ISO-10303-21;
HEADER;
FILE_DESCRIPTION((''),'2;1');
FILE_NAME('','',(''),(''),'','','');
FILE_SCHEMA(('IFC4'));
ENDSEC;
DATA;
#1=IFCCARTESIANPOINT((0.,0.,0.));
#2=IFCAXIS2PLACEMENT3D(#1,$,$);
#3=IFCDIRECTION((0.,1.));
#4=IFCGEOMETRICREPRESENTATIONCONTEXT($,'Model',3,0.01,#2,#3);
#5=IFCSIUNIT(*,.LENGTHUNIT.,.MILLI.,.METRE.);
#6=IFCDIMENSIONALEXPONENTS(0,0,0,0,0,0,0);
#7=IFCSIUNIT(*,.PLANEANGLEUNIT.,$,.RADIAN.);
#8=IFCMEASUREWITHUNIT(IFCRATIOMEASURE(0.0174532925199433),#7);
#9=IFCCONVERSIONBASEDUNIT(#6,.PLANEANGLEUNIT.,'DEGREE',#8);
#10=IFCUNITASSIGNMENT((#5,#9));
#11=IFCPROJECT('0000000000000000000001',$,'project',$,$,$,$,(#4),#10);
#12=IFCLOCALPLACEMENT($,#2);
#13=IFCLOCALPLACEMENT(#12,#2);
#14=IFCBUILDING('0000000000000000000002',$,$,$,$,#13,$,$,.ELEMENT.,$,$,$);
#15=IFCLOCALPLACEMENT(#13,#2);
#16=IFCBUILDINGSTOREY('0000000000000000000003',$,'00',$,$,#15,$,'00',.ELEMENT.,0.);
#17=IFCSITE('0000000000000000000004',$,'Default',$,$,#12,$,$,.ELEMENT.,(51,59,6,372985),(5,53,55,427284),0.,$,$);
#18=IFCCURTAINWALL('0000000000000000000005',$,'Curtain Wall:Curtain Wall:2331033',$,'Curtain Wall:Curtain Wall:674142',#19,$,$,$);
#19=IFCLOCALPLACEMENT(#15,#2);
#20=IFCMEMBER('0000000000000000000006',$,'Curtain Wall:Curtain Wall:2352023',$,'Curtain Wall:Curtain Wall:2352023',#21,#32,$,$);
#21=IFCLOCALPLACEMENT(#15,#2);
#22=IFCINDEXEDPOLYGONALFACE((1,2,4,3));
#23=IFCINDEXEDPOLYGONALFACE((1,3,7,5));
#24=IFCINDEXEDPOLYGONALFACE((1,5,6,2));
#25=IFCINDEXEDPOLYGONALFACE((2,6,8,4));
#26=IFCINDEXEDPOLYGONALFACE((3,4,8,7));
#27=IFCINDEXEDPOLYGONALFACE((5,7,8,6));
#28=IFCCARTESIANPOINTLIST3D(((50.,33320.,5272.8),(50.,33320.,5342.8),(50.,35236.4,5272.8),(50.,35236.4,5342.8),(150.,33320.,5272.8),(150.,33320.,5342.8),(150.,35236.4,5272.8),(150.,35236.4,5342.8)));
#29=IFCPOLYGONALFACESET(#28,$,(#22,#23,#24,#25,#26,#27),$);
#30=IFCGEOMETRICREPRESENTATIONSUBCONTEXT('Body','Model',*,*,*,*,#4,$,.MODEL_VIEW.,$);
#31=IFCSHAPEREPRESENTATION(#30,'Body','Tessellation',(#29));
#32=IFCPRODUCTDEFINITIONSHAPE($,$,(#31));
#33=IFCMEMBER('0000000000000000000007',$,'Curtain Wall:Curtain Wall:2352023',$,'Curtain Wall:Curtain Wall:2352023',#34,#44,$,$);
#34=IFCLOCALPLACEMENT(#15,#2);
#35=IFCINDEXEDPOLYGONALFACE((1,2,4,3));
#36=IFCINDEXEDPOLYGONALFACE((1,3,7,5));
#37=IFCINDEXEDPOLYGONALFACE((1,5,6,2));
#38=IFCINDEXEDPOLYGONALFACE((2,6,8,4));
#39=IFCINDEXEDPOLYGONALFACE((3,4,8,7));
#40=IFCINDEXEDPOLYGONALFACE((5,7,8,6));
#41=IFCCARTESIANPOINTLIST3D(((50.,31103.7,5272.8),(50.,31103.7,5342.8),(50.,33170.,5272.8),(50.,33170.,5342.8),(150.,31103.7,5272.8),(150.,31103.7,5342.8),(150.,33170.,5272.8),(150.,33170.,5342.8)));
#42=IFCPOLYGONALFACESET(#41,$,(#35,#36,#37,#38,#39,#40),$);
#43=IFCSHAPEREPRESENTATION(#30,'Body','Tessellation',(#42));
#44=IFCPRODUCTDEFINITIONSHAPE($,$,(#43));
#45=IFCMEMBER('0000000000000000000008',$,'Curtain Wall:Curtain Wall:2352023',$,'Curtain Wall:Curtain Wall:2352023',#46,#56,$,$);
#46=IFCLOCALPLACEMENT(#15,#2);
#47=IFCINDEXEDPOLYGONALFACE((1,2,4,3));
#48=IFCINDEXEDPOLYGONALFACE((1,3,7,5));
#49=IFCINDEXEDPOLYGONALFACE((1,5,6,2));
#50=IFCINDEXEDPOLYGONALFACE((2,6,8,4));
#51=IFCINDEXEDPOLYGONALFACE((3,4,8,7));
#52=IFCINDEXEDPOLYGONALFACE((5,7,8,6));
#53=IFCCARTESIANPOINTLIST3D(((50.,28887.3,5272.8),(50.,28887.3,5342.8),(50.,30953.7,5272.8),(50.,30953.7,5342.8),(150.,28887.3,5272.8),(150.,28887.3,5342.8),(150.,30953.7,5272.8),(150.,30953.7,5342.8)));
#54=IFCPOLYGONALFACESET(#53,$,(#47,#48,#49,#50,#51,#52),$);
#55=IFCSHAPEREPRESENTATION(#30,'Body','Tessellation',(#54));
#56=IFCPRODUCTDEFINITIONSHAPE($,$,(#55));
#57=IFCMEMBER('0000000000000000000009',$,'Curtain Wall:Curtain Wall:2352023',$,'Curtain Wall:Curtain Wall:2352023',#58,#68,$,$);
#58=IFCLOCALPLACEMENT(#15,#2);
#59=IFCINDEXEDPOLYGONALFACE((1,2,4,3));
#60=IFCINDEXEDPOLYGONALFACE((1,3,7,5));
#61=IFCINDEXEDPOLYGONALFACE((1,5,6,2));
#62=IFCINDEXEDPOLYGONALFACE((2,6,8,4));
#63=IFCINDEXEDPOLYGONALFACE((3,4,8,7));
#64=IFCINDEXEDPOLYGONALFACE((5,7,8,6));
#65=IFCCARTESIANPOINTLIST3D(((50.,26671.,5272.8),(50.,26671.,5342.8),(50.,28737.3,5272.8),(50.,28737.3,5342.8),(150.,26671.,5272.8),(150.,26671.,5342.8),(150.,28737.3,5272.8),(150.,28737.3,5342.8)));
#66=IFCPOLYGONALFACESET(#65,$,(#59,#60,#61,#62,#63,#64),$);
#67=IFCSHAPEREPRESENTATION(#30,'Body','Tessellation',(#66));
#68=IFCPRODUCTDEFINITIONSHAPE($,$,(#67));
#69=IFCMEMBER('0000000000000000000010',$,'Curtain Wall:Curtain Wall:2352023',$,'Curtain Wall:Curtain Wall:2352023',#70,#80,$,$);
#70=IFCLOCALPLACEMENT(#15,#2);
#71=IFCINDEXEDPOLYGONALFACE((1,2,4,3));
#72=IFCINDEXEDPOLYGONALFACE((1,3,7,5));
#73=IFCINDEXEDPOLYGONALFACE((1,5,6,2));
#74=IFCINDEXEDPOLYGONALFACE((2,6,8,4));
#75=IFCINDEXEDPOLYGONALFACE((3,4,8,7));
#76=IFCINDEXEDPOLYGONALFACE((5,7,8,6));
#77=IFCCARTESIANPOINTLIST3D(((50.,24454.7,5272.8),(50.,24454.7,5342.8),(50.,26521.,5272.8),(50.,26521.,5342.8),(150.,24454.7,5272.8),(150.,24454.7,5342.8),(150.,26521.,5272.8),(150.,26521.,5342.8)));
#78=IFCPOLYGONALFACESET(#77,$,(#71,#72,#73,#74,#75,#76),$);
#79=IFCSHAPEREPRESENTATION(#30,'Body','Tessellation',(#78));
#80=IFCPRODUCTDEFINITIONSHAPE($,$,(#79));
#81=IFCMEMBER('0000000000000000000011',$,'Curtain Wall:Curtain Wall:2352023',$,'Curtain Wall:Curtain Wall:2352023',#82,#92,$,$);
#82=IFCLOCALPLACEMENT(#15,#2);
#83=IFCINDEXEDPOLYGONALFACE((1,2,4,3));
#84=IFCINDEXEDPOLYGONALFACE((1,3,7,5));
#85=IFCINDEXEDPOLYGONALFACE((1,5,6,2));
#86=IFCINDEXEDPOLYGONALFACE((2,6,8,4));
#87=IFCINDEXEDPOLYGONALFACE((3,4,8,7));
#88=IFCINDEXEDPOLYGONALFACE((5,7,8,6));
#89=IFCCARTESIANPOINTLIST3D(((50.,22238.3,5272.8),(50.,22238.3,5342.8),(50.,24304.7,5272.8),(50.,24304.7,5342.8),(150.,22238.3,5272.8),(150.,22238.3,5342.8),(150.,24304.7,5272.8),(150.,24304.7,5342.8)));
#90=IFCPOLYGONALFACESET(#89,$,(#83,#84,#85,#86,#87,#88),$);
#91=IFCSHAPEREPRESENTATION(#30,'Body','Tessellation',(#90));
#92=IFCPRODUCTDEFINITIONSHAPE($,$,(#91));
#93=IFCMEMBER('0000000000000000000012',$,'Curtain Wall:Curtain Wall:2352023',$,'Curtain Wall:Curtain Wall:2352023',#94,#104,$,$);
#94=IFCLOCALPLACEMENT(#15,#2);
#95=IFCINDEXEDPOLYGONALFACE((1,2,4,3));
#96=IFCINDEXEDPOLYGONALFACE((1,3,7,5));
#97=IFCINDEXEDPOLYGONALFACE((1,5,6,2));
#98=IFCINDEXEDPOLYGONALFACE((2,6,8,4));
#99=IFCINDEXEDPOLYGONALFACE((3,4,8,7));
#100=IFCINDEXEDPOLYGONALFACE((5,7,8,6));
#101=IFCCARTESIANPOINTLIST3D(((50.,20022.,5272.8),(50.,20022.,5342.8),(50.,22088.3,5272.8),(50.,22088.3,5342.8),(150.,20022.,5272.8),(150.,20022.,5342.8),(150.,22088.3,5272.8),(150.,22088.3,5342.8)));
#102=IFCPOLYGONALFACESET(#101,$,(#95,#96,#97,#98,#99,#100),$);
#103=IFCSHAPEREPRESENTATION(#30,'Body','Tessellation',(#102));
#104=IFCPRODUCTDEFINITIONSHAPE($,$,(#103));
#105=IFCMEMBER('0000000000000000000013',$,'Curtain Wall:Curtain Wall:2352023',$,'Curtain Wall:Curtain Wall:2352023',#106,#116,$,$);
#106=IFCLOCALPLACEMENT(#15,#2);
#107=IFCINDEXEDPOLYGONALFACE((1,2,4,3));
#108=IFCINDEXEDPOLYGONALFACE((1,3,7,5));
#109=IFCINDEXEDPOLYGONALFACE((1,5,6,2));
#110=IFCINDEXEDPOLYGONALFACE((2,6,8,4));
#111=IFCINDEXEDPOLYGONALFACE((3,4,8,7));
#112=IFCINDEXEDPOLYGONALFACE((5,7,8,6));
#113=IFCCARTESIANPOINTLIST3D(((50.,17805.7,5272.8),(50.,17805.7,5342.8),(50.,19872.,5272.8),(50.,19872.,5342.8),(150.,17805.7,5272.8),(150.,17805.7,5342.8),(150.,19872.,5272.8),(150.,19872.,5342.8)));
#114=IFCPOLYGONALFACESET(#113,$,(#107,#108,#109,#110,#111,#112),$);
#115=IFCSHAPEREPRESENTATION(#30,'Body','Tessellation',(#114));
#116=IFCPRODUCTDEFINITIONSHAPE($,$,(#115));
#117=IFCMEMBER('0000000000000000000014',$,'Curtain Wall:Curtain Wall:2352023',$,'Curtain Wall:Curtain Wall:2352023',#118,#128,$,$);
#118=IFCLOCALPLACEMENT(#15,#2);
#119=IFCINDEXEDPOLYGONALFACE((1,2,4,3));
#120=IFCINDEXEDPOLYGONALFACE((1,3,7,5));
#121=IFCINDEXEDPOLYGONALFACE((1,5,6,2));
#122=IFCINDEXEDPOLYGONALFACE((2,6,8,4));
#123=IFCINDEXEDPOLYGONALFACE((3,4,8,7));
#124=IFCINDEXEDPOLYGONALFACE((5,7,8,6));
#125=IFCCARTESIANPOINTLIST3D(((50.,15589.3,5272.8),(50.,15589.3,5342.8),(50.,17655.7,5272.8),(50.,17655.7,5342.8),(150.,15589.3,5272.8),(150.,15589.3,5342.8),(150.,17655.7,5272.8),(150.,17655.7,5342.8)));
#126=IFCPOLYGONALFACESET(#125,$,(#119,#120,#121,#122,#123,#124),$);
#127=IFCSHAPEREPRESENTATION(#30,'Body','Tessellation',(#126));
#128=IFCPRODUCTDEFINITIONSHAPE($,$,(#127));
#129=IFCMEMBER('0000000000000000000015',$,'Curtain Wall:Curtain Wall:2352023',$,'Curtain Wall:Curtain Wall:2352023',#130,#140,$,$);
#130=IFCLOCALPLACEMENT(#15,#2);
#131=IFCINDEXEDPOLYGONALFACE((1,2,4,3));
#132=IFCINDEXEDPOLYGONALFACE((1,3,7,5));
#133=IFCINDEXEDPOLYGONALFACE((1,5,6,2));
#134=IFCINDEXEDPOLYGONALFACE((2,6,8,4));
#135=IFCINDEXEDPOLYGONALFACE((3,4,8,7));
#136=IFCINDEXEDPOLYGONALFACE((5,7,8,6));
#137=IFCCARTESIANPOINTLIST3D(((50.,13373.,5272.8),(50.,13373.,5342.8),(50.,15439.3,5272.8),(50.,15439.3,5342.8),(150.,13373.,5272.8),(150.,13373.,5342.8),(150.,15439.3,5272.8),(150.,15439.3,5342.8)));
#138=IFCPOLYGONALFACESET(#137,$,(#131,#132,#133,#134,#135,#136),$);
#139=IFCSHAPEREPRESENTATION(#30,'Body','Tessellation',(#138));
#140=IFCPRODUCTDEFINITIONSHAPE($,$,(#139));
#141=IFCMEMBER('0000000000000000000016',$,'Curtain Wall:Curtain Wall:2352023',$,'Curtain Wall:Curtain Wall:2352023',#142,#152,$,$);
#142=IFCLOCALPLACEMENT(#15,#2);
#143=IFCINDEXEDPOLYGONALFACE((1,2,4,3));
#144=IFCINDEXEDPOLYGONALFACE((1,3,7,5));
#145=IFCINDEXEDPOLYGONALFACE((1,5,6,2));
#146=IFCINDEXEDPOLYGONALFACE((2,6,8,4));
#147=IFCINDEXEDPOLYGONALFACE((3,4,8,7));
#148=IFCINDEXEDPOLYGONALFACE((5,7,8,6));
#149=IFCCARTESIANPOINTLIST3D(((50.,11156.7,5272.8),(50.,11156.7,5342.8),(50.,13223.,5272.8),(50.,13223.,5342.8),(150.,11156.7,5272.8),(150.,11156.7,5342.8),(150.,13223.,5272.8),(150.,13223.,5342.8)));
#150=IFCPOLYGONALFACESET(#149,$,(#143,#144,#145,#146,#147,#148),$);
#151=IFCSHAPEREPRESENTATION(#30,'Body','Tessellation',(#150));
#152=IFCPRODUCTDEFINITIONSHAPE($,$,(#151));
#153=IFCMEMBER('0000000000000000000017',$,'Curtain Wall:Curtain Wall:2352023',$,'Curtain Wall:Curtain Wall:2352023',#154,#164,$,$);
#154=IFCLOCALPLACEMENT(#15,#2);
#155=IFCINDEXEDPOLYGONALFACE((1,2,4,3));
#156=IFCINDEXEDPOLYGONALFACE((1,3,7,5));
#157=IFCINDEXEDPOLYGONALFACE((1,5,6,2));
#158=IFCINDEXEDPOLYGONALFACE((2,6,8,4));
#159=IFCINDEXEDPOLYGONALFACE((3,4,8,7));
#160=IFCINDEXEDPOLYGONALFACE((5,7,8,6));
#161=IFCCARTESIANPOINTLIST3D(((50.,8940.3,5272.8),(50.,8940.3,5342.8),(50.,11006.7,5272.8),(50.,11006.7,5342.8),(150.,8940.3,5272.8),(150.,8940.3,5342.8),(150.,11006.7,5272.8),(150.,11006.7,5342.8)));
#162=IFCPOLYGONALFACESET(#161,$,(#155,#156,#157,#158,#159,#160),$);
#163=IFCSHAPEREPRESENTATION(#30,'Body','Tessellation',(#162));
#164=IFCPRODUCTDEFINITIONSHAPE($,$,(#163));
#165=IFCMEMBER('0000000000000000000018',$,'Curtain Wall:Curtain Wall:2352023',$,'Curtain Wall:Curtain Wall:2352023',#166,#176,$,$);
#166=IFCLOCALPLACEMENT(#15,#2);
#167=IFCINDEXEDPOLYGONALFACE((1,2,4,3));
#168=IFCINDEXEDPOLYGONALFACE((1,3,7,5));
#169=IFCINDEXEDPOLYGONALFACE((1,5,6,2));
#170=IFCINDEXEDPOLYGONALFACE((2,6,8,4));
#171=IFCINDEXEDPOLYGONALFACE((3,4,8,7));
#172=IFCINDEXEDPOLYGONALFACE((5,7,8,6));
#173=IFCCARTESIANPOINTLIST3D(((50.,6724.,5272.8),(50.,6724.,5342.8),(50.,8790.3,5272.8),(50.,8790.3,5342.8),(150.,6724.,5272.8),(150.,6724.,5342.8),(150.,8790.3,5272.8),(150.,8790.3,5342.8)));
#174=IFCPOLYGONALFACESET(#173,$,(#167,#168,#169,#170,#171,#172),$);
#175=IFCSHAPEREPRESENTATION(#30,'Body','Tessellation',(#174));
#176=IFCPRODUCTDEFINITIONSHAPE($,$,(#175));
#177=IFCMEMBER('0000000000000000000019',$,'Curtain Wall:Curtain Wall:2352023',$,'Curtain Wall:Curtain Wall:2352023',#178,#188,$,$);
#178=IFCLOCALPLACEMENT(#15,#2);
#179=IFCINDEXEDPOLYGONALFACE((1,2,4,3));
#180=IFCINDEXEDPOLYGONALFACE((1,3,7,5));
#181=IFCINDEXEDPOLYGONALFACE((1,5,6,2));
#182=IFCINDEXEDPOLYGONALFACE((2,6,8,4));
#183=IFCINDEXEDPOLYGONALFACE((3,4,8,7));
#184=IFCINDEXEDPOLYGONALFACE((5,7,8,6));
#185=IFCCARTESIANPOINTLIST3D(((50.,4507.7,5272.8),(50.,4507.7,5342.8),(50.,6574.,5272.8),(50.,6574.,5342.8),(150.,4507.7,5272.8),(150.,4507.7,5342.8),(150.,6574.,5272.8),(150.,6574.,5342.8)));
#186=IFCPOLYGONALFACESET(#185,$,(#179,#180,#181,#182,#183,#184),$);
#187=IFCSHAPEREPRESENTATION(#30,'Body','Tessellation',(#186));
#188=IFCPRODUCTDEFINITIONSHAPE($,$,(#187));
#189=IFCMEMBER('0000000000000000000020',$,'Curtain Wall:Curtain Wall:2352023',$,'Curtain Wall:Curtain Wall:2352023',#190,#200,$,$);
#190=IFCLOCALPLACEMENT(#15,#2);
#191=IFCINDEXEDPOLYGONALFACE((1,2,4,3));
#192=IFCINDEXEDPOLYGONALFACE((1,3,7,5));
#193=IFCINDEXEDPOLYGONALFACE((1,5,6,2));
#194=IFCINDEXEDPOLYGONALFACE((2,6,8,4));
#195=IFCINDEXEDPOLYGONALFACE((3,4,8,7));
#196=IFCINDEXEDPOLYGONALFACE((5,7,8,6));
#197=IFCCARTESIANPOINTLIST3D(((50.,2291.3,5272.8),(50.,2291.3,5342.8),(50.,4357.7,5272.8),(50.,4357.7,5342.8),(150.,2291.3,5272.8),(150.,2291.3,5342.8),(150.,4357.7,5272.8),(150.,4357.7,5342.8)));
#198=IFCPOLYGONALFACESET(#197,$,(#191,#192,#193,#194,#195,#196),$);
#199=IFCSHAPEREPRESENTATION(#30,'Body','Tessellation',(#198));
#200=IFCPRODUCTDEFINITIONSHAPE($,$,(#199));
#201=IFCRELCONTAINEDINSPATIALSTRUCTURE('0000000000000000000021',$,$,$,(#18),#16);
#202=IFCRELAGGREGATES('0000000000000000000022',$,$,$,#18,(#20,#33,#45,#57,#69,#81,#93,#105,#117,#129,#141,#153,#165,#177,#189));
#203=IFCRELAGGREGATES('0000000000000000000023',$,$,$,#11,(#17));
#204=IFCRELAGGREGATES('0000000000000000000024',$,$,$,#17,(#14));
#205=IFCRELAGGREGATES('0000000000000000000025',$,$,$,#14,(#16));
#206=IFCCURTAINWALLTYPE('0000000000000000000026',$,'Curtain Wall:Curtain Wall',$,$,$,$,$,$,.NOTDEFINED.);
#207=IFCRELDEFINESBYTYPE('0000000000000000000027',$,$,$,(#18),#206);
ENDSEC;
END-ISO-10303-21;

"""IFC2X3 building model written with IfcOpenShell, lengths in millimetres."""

from ifc_helpers import new_model, entity, si_unit, converted_unit, direction, frame, frame_2d, origin, origin_2d_with_axis, place, context, subcontext, project, spatial, rectangle, extrude, type_object, element, aggregate, save


model = new_model("IFC2X3")

# Units and contexts
model_context = context("Model", 3, precision=0.01, world=origin(), true_north=direction((0.0, 1.0)))
body_context = subcontext(model_context, "Body", "Model", "MODEL_VIEW")
ifc_project = project(units=[si_unit("LENGTHUNIT", "METRE", prefix="MILLI"), converted_unit("PLANEANGLEUNIT", "DEGREE", entity("IfcRatioMeasure", 0.0174532925199433), si_unit("PLANEANGLEUNIT", "RADIAN"), dimensions=[0, 0, 0, 0, 0, 0, 0])], contexts=[model_context])

# Site, building, storey
site_placement = place(None, origin())
site = spatial("IfcSite", under=ifc_project, at=site_placement, Name="Default", CompositionType="ELEMENT", RefLatitude=(51, 59, 6, 372985), RefLongitude=(5, 53, 55, 427284), RefElevation=0.0)
building_placement = place(site_placement, origin())
building = spatial("IfcBuilding", under=site, at=building_placement, CompositionType="ELEMENT")
storey_placement = place(building_placement, origin())
storey = spatial("IfcBuildingStorey", under=building, at=storey_placement, Name="00", LongName="00", CompositionType="ELEMENT", Elevation=0.0)

# Curtain wall, members
curtain_wall_type = type_object("IfcCurtainWallType", Name="Curtain Wall:Curtain Wall", PredefinedType="NOTDEFINED")
curtain_wall_placement = place(storey_placement, origin())
curtain_wall = element("IfcCurtainWall", 1, at=curtain_wall_placement, inside=storey, type_object=curtain_wall_type, Name="Curtain Wall:Curtain Wall:2331033", ObjectType="Curtain Wall:Curtain Wall:674142")
member_1_placement = place(curtain_wall_placement, origin())
member_1 = element("IfcMember", 2, at=member_1_placement, Name="Curtain Wall:Curtain Wall:2352023", ObjectType="Curtain Wall:Curtain Wall:2352023", context=body_context, shape_type="SweptSolid", body=[
    extrude(rectangle(XDim=70.0, YDim=100.0, at=frame_2d((0.0, 0.0), x_axis=(1.0, 0.0))), frame((100.0, 33320.0, 5307.8), z_axis=(0.0, 1.0, 0.0), x_axis=(0.0, 0.0, -1.0)), (0.0, 0.0, 1.0), 1916.3),
])
member_2_placement = place(curtain_wall_placement, origin())
member_2 = element("IfcMember", 3, at=member_2_placement, Name="Curtain Wall:Curtain Wall:2352023", ObjectType="Curtain Wall:Curtain Wall:2352023", context=body_context, shape_type="SweptSolid", body=[
    extrude(rectangle(XDim=70.0, YDim=100.0, at=origin_2d_with_axis()), frame((100.0, 31103.7, 5307.8), z_axis=(0.0, 1.0, 0.0), x_axis=(0.0, 0.0, -1.0)), (0.0, 0.0, 1.0), 2066.3),
])
member_3_placement = place(curtain_wall_placement, origin())
member_3 = element("IfcMember", 4, at=member_3_placement, Name="Curtain Wall:Curtain Wall:2352023", ObjectType="Curtain Wall:Curtain Wall:2352023", context=body_context, shape_type="SweptSolid", body=[
    extrude(rectangle(XDim=70.0, YDim=100.0, at=frame_2d((0.0, 0.0), x_axis=(1.0, 0.0))), frame((100.0, 28887.3, 5307.8), z_axis=(0.0, 1.0, 0.0), x_axis=(0.0, 0.0, -1.0)), (0.0, 0.0, 1.0), 2066.3),
])
member_4_placement = place(curtain_wall_placement, origin())
member_4 = element("IfcMember", 5, at=member_4_placement, Name="Curtain Wall:Curtain Wall:2352023", ObjectType="Curtain Wall:Curtain Wall:2352023", context=body_context, shape_type="SweptSolid", body=[
    extrude(rectangle(XDim=70.0, YDim=100.0, at=origin_2d_with_axis()), frame((100.0, 26671.0, 5307.8), z_axis=(0.0, 1.0, 0.0), x_axis=(0.0, 0.0, -1.0)), (0.0, 0.0, 1.0), 2066.3),
])
member_5_placement = place(curtain_wall_placement, origin())
member_5 = element("IfcMember", 6, at=member_5_placement, Name="Curtain Wall:Curtain Wall:2352023", ObjectType="Curtain Wall:Curtain Wall:2352023", context=body_context, shape_type="SweptSolid", body=[
    extrude(rectangle(XDim=70.0, YDim=100.0, at=origin_2d_with_axis()), frame((100.0, 24454.7, 5307.8), z_axis=(0.0, 1.0, 0.0), x_axis=(0.0, 0.0, -1.0)), (0.0, 0.0, 1.0), 2066.3),
])
member_6_placement = place(curtain_wall_placement, origin())
member_6 = element("IfcMember", 7, at=member_6_placement, Name="Curtain Wall:Curtain Wall:2352023", ObjectType="Curtain Wall:Curtain Wall:2352023", context=body_context, shape_type="SweptSolid", body=[
    extrude(rectangle(XDim=70.0, YDim=100.0, at=frame_2d((0.0, 0.0), x_axis=(1.0, 0.0))), frame((100.0, 22238.3, 5307.8), z_axis=(0.0, 1.0, 0.0), x_axis=(0.0, 0.0, -1.0)), (0.0, 0.0, 1.0), 2066.3),
])
member_7_placement = place(curtain_wall_placement, origin())
member_7 = element("IfcMember", 8, at=member_7_placement, Name="Curtain Wall:Curtain Wall:2352023", ObjectType="Curtain Wall:Curtain Wall:2352023", context=body_context, shape_type="SweptSolid", body=[
    extrude(rectangle(XDim=70.0, YDim=100.0, at=origin_2d_with_axis()), frame((100.0, 20022.0, 5307.8), z_axis=(0.0, 1.0, 0.0), x_axis=(0.0, 0.0, -1.0)), (0.0, 0.0, 1.0), 2066.3),
])
member_8_placement = place(curtain_wall_placement, origin())
member_8 = element("IfcMember", 9, at=member_8_placement, Name="Curtain Wall:Curtain Wall:2352023", ObjectType="Curtain Wall:Curtain Wall:2352023", context=body_context, shape_type="SweptSolid", body=[
    extrude(rectangle(XDim=70.0, YDim=100.0, at=frame_2d((0.0, 0.0), x_axis=(1.0, 0.0))), frame((100.0, 17805.7, 5307.8), z_axis=(0.0, 1.0, 0.0), x_axis=(0.0, 0.0, -1.0)), (0.0, 0.0, 1.0), 2066.3),
])
member_9_placement = place(curtain_wall_placement, origin())
member_9 = element("IfcMember", 10, at=member_9_placement, Name="Curtain Wall:Curtain Wall:2352023", ObjectType="Curtain Wall:Curtain Wall:2352023", context=body_context, shape_type="SweptSolid", body=[
    extrude(rectangle(XDim=70.0, YDim=100.0, at=origin_2d_with_axis()), frame((100.0, 15589.3, 5307.8), z_axis=(0.0, 1.0, 0.0), x_axis=(0.0, 0.0, -1.0)), (0.0, 0.0, 1.0), 2066.3),
])
member_10_placement = place(curtain_wall_placement, origin())
member_10 = element("IfcMember", 11, at=member_10_placement, Name="Curtain Wall:Curtain Wall:2352023", ObjectType="Curtain Wall:Curtain Wall:2352023", context=body_context, shape_type="SweptSolid", body=[
    extrude(rectangle(XDim=70.0, YDim=100.0, at=origin_2d_with_axis()), frame((100.0, 13373.0, 5307.8), z_axis=(0.0, 1.0, 0.0), x_axis=(0.0, 0.0, -1.0)), (0.0, 0.0, 1.0), 2066.3),
])
member_11_placement = place(curtain_wall_placement, origin())
member_11 = element("IfcMember", 12, at=member_11_placement, Name="Curtain Wall:Curtain Wall:2352023", ObjectType="Curtain Wall:Curtain Wall:2352023", context=body_context, shape_type="SweptSolid", body=[
    extrude(rectangle(XDim=70.0, YDim=100.0, at=origin_2d_with_axis()), frame((100.0, 11156.7, 5307.8), z_axis=(0.0, 1.0, 0.0), x_axis=(0.0, 0.0, -1.0)), (0.0, 0.0, 1.0), 2066.3),
])
member_12_placement = place(curtain_wall_placement, origin())
member_12 = element("IfcMember", 13, at=member_12_placement, Name="Curtain Wall:Curtain Wall:2352023", ObjectType="Curtain Wall:Curtain Wall:2352023", context=body_context, shape_type="SweptSolid", body=[
    extrude(rectangle(XDim=70.0, YDim=100.0, at=origin_2d_with_axis()), frame((100.0, 8940.3, 5307.8), z_axis=(0.0, 1.0, 0.0), x_axis=(0.0, 0.0, -1.0)), (0.0, 0.0, 1.0), 2066.3),
])
member_13_placement = place(curtain_wall_placement, origin())
member_13 = element("IfcMember", 14, at=member_13_placement, Name="Curtain Wall:Curtain Wall:2352023", ObjectType="Curtain Wall:Curtain Wall:2352023", context=body_context, shape_type="SweptSolid", body=[
    extrude(rectangle(XDim=70.0, YDim=100.0, at=origin_2d_with_axis()), frame((100.0, 6724.0, 5307.8), z_axis=(0.0, 1.0, 0.0), x_axis=(0.0, 0.0, -1.0)), (0.0, 0.0, 1.0), 2066.3),
])
member_14_placement = place(curtain_wall_placement, origin())
member_14 = element("IfcMember", 15, at=member_14_placement, Name="Curtain Wall:Curtain Wall:2352023", ObjectType="Curtain Wall:Curtain Wall:2352023", context=body_context, shape_type="SweptSolid", body=[
    extrude(rectangle(XDim=70.0, YDim=100.0, at=origin_2d_with_axis()), frame((100.0, 4507.7, 5307.8), z_axis=(0.0, 1.0, 0.0), x_axis=(0.0, 0.0, -1.0)), (0.0, 0.0, 1.0), 2066.3),
])
member_15_placement = place(curtain_wall_placement, origin())
member_15 = element("IfcMember", 16, at=member_15_placement, Name="Curtain Wall:Curtain Wall:2352023", ObjectType="Curtain Wall:Curtain Wall:2352023", context=body_context, shape_type="SweptSolid", body=[
    extrude(rectangle(XDim=70.0, YDim=100.0, at=origin_2d_with_axis()), frame((100.0, 2291.3, 5307.8), z_axis=(0.0, 1.0, 0.0), x_axis=(0.0, 0.0, -1.0)), (0.0, 0.0, 1.0), 2066.3),
])
aggregate(curtain_wall, [member_1, member_2, member_3, member_4, member_5, member_6, member_7, member_8, member_9, member_10, member_11, member_12, member_13, member_14, member_15])

save(model, "model.ifc")
